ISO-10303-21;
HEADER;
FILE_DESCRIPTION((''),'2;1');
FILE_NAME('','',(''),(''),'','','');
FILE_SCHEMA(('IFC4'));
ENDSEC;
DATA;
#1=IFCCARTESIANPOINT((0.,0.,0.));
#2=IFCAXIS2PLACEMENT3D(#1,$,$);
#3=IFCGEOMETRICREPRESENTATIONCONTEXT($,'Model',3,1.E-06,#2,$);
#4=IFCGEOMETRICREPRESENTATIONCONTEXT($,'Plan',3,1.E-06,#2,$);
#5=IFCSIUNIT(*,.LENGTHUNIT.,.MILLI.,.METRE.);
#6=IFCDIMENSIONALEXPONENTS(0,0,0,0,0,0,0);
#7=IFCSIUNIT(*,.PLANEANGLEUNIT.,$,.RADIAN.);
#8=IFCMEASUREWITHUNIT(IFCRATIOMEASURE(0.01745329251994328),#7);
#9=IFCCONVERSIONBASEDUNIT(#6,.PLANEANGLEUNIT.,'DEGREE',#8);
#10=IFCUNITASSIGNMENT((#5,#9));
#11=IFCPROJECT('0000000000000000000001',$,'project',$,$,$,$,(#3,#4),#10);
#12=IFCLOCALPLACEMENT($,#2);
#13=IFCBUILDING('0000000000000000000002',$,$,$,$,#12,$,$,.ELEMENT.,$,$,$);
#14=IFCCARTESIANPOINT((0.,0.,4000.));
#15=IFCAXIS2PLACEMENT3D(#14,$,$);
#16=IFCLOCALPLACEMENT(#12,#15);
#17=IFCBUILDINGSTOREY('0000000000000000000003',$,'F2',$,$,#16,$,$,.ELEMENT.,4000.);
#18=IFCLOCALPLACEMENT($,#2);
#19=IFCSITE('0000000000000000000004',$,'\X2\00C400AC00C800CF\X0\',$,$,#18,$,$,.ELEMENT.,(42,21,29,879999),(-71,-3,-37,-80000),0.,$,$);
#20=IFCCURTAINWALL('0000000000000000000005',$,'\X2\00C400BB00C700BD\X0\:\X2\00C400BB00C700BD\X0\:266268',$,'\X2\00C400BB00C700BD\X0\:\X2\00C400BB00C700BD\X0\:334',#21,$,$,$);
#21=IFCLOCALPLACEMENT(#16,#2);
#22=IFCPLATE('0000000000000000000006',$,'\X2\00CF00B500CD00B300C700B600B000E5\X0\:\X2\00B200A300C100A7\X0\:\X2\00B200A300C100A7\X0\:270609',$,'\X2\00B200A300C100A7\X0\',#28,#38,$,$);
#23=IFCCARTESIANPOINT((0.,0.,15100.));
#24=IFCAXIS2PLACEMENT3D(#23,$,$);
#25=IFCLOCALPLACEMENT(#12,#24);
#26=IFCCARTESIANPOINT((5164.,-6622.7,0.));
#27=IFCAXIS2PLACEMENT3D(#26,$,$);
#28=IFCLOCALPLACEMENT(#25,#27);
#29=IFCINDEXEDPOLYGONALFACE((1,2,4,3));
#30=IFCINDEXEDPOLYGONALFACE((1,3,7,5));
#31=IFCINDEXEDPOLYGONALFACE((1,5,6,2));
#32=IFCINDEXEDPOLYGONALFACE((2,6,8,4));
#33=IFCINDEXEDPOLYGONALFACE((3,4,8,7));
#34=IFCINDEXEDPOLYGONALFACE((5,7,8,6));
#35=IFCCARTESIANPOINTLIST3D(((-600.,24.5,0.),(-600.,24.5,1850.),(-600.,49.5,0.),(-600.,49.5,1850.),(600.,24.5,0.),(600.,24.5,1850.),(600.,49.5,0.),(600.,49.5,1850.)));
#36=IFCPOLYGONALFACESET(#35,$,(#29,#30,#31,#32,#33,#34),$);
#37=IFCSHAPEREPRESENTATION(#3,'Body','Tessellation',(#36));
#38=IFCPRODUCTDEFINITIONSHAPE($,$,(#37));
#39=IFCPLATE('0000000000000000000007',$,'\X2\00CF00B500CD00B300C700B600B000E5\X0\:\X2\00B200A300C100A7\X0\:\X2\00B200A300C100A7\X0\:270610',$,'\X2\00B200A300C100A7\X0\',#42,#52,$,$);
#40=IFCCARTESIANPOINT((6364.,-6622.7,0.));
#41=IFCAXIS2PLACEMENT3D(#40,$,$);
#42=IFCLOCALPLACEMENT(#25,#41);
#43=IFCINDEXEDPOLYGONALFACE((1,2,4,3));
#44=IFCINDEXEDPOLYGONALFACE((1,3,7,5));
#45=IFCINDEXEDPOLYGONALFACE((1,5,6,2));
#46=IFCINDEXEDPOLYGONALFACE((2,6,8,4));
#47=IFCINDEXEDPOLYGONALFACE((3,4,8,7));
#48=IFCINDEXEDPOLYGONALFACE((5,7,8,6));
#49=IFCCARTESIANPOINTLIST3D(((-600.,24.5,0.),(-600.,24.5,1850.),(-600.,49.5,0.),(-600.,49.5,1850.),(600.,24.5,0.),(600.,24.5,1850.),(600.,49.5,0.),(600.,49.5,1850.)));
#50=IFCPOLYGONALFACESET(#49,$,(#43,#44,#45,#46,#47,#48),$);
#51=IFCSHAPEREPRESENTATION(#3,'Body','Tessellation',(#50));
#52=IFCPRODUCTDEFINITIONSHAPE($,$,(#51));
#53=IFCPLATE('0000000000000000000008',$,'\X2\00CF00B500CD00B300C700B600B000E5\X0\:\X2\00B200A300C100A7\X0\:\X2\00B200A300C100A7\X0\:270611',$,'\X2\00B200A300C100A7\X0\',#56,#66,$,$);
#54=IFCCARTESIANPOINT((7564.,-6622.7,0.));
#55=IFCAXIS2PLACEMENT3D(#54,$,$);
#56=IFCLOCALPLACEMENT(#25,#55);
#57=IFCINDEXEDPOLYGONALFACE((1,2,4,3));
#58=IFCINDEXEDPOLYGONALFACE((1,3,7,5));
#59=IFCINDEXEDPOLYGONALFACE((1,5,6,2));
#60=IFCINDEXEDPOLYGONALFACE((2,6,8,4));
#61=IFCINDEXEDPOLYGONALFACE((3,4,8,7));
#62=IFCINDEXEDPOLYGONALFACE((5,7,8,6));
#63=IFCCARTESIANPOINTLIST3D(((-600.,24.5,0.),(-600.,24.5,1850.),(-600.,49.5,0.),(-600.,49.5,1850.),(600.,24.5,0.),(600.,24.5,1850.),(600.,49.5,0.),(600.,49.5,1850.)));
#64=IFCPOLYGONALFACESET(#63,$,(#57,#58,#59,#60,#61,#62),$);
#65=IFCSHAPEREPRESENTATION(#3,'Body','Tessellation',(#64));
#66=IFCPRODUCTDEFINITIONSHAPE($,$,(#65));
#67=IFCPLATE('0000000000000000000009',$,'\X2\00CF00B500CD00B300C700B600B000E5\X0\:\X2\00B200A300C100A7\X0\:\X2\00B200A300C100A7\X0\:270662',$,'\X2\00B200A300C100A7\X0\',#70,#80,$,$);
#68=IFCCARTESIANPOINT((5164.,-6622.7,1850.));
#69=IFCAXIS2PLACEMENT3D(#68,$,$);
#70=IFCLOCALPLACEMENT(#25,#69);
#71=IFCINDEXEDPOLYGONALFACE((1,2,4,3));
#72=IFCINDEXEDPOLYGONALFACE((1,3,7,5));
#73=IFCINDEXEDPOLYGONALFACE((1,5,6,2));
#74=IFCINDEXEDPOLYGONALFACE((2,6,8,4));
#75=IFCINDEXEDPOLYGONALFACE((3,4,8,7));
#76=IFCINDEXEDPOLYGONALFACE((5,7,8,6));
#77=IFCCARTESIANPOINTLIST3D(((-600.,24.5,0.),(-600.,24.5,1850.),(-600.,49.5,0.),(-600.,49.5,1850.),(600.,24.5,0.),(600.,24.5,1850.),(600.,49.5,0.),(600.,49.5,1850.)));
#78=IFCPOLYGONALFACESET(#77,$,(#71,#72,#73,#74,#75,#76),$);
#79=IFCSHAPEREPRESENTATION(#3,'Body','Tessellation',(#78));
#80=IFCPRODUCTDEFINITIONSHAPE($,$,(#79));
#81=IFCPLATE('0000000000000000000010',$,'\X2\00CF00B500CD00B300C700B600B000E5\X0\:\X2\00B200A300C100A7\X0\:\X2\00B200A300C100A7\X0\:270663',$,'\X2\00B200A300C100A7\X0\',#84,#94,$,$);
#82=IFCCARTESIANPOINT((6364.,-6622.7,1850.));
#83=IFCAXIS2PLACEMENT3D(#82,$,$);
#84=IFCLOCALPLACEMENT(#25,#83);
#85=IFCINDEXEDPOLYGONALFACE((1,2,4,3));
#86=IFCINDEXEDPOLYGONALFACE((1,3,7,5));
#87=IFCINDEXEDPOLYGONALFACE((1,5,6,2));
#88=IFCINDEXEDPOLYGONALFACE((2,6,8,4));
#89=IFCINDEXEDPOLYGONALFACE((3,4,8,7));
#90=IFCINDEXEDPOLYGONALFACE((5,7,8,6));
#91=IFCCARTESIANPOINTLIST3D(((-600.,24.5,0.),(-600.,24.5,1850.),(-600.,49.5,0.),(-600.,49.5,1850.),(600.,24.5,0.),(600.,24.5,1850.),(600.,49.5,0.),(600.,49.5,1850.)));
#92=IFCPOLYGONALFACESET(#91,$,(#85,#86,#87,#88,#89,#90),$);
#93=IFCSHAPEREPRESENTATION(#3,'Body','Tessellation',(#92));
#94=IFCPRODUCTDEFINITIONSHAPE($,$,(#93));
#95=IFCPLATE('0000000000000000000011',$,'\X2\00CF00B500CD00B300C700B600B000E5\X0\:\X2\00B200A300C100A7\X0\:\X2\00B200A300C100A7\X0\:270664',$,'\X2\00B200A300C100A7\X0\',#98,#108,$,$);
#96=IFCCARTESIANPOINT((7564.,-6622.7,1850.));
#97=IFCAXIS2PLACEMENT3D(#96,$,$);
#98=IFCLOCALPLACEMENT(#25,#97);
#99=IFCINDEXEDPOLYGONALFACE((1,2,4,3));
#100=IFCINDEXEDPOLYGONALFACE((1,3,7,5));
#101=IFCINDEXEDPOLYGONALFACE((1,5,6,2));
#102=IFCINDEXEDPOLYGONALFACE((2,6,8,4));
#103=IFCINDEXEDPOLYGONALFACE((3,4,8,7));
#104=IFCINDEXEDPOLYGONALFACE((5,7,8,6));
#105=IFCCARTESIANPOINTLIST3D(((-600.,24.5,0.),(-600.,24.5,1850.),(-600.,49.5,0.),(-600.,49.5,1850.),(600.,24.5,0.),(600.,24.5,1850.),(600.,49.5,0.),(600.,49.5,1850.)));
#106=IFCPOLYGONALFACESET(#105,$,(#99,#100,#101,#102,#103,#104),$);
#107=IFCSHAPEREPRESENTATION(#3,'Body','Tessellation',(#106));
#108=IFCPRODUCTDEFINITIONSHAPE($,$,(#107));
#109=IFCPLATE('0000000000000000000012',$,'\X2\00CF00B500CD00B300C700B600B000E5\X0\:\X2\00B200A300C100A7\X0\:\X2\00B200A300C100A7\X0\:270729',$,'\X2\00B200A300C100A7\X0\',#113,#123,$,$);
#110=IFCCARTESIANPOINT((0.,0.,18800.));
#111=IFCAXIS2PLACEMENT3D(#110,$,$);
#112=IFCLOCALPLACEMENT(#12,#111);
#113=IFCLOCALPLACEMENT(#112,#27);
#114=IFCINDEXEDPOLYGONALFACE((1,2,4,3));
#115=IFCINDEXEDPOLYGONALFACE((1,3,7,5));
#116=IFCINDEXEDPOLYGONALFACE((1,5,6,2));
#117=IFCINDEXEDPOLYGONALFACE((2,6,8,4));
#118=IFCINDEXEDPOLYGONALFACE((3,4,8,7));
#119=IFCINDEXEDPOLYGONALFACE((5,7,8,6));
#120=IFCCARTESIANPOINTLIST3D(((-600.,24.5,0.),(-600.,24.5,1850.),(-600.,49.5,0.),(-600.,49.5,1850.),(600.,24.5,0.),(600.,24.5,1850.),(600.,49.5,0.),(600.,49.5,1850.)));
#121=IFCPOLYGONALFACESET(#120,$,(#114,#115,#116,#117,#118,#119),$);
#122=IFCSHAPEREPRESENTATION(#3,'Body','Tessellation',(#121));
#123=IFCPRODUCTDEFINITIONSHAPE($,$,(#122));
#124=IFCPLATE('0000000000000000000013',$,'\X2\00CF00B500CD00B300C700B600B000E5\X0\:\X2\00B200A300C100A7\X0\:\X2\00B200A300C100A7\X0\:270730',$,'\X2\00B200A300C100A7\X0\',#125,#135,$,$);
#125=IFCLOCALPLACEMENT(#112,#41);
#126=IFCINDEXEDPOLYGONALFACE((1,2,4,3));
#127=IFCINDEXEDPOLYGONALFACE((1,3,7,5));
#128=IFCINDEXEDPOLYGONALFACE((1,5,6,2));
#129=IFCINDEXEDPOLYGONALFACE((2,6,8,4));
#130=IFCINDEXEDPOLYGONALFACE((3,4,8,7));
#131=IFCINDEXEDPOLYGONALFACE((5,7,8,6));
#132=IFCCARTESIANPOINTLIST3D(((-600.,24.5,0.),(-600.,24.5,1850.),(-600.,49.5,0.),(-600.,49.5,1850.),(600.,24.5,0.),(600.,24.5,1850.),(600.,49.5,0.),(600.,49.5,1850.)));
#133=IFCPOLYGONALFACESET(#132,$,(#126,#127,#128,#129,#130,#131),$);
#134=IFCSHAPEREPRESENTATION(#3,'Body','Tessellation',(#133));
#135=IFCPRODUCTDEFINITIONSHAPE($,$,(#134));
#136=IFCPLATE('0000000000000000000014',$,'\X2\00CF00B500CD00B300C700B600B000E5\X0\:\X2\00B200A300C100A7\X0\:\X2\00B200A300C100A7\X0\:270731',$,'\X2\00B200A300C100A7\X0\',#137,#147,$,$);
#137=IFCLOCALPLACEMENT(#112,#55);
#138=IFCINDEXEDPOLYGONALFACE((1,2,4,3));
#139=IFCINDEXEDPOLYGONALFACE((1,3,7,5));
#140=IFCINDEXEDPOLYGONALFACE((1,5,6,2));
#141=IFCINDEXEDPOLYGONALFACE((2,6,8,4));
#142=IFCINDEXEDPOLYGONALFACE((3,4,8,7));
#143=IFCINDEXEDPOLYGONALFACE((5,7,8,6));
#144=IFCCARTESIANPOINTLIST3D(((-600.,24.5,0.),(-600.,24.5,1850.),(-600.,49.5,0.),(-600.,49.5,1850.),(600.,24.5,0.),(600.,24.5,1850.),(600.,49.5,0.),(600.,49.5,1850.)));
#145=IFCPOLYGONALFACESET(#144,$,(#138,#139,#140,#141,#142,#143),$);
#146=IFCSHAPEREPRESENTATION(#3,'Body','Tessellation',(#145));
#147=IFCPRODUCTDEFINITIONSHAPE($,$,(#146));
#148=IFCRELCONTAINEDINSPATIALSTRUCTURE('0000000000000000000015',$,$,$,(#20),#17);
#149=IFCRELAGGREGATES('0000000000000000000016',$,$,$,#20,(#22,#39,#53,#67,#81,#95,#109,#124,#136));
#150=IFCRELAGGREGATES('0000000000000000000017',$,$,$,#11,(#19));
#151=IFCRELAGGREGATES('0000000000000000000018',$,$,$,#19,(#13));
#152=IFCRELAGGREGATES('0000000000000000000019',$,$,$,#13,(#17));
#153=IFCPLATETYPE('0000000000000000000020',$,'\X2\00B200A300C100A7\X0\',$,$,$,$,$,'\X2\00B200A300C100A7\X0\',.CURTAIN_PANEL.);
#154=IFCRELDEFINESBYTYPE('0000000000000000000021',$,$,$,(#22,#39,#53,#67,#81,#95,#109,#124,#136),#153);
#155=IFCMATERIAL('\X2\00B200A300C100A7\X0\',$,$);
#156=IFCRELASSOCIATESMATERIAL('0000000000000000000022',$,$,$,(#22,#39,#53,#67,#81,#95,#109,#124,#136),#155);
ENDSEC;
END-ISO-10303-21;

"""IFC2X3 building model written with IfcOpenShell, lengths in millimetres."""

from ifc_helpers import new_model, entity, si_unit, converted_unit, frame, origin, origin_2d_with_axis, place, context, project, spatial, rectangle, extrude, source, transform, mapped, material, type_object, type_shapes, element, aggregate, save


model = new_model("IFC2X3")

# Units and contexts
model_context = context("Model", 3, precision=1e-06, world=origin())
plan_context = context("Plan", 3, precision=1e-06, world=origin())
ifc_project = project(units=[si_unit("LENGTHUNIT", "METRE", prefix="MILLI"), converted_unit("PLANEANGLEUNIT", "DEGREE", entity("IfcRatioMeasure", 0.01745329251994328), si_unit("PLANEANGLEUNIT", "RADIAN"), dimensions=[0, 0, 0, 0, 0, 0, 0])], contexts=[model_context, plan_context])

# Site, building, storey
site_placement = place(None, origin())
site = spatial("IfcSite", under=ifc_project, at=site_placement, Name="Ä¬ÈÏ", CompositionType="ELEMENT", RefLatitude=(42, 21, 29, 879999), RefLongitude=(-71, -3, -37, -80000), RefElevation=0.0)
building_placement = place(None, origin())
building = spatial("IfcBuilding", under=site, at=building_placement, CompositionType="ELEMENT")
storey_placement = place(building_placement, frame((0.0, 0.0, 4000.0)))
storey = spatial("IfcBuildingStorey", under=building, at=storey_placement, Name="F2", CompositionType="ELEMENT", Elevation=4000.0)

# Curtain wall, plates
curtain_wall_placement = place(storey_placement, origin())
curtain_wall = element("IfcCurtainWall", 1, at=curtain_wall_placement, inside=storey, Name="Ä»Ç½:Ä»Ç½:266268", ObjectType="Ä»Ç½:Ä»Ç½:334")
placement_1 = place(building_placement, frame((0.0, 0.0, 15100.0)))
placement_2 = place(building_placement, frame((0.0, 0.0, 18800.0)))
ifc_material_1 = material(Name="²£Á§")
plate_type = type_object("IfcPlateType", Name="²£Á§", ElementType="²£Á§", PredefinedType="CURTAIN_PANEL")
shared_shape_1 = source(origin(), model_context, "Body", "SweptSolid", [
    extrude(rectangle(XDim=25.0, YDim=1200.0, at=origin_2d_with_axis()), frame((0.0, 37.0, 0.0), z_axis=(0.0, 0.0, 1.0), x_axis=(0.0, 1.0, 0.0)), (0.0, 0.0, 1.0), 1850.0),
])
type_shapes(plate_type, [shared_shape_1])
plate_1_placement = place(placement_1, frame((5164.0, -6622.7, 0.0)))
plate_1 = element("IfcPlate", 2, at=plate_1_placement, type_object=plate_type, material=ifc_material_1, Name="ÏµÍ³Ç¶°å:²£Á§:²£Á§:270609", ObjectType="²£Á§", context=model_context, shape_type="MappedRepresentation", body=[
    mapped(shared_shape_1, transform((0.0, 0.0, 0.0), scale=1.0)),
])
plate_2_placement = place(placement_1, frame((6364.0, -6622.7, 0.0)))
plate_2 = element("IfcPlate", 3, at=plate_2_placement, type_object=plate_type, material=ifc_material_1, Name="ÏµÍ³Ç¶°å:²£Á§:²£Á§:270610", ObjectType="²£Á§", context=model_context, shape_type="MappedRepresentation", body=[
    mapped(shared_shape_1, transform((0.0, 0.0, 0.0), scale=1.0)),
])
plate_3_placement = place(placement_1, frame((7564.0, -6622.7, 0.0)))
plate_3 = element("IfcPlate", 4, at=plate_3_placement, type_object=plate_type, material=ifc_material_1, Name="ÏµÍ³Ç¶°å:²£Á§:²£Á§:270611", ObjectType="²£Á§", context=model_context, shape_type="MappedRepresentation", body=[
    mapped(shared_shape_1, transform((0.0, 0.0, 0.0), scale=1.0)),
])
plate_4_placement = place(placement_1, frame((5164.0, -6622.7, 1850.0)))
plate_4 = element("IfcPlate", 5, at=plate_4_placement, type_object=plate_type, material=ifc_material_1, Name="ÏµÍ³Ç¶°å:²£Á§:²£Á§:270662", ObjectType="²£Á§", context=model_context, shape_type="MappedRepresentation", body=[
    mapped(shared_shape_1, transform((0.0, 0.0, 0.0), scale=1.0)),
])
plate_5_placement = place(placement_1, frame((6364.0, -6622.7, 1850.0)))
plate_5 = element("IfcPlate", 6, at=plate_5_placement, type_object=plate_type, material=ifc_material_1, Name="ÏµÍ³Ç¶°å:²£Á§:²£Á§:270663", ObjectType="²£Á§", context=model_context, shape_type="MappedRepresentation", body=[
    mapped(shared_shape_1, transform((0.0, 0.0, 0.0), scale=1.0)),
])
plate_6_placement = place(placement_1, frame((7564.0, -6622.7, 1850.0)))
plate_6 = element("IfcPlate", 7, at=plate_6_placement, type_object=plate_type, material=ifc_material_1, Name="ÏµÍ³Ç¶°å:²£Á§:²£Á§:270664", ObjectType="²£Á§", context=model_context, shape_type="MappedRepresentation", body=[
    mapped(shared_shape_1, transform((0.0, 0.0, 0.0), scale=1.0)),
])
plate_7_placement = place(placement_2, frame((5164.0, -6622.7, 0.0)))
plate_7 = element("IfcPlate", 8, at=plate_7_placement, type_object=plate_type, material=ifc_material_1, Name="ÏµÍ³Ç¶°å:²£Á§:²£Á§:270729", ObjectType="²£Á§", context=model_context, shape_type="MappedRepresentation", body=[
    mapped(shared_shape_1, transform((0.0, 0.0, 0.0), scale=1.0)),
])
plate_8_placement = place(placement_2, frame((6364.0, -6622.7, 0.0)))
plate_8 = element("IfcPlate", 9, at=plate_8_placement, type_object=plate_type, material=ifc_material_1, Name="ÏµÍ³Ç¶°å:²£Á§:²£Á§:270730", ObjectType="²£Á§", context=model_context, shape_type="MappedRepresentation", body=[
    mapped(shared_shape_1, transform((0.0, 0.0, 0.0), scale=1.0)),
])
plate_9_placement = place(placement_2, frame((7564.0, -6622.7, 0.0)))
plate_9 = element("IfcPlate", 10, at=plate_9_placement, type_object=plate_type, material=ifc_material_1, Name="ÏµÍ³Ç¶°å:²£Á§:²£Á§:270731", ObjectType="²£Á§", context=model_context, shape_type="MappedRepresentation", body=[
    mapped(shared_shape_1, transform((0.0, 0.0, 0.0), scale=1.0)),
])
aggregate(curtain_wall, [plate_1, plate_2, plate_3, plate_4, plate_5, plate_6, plate_7, plate_8, plate_9])

save(model, "model.ifc")
